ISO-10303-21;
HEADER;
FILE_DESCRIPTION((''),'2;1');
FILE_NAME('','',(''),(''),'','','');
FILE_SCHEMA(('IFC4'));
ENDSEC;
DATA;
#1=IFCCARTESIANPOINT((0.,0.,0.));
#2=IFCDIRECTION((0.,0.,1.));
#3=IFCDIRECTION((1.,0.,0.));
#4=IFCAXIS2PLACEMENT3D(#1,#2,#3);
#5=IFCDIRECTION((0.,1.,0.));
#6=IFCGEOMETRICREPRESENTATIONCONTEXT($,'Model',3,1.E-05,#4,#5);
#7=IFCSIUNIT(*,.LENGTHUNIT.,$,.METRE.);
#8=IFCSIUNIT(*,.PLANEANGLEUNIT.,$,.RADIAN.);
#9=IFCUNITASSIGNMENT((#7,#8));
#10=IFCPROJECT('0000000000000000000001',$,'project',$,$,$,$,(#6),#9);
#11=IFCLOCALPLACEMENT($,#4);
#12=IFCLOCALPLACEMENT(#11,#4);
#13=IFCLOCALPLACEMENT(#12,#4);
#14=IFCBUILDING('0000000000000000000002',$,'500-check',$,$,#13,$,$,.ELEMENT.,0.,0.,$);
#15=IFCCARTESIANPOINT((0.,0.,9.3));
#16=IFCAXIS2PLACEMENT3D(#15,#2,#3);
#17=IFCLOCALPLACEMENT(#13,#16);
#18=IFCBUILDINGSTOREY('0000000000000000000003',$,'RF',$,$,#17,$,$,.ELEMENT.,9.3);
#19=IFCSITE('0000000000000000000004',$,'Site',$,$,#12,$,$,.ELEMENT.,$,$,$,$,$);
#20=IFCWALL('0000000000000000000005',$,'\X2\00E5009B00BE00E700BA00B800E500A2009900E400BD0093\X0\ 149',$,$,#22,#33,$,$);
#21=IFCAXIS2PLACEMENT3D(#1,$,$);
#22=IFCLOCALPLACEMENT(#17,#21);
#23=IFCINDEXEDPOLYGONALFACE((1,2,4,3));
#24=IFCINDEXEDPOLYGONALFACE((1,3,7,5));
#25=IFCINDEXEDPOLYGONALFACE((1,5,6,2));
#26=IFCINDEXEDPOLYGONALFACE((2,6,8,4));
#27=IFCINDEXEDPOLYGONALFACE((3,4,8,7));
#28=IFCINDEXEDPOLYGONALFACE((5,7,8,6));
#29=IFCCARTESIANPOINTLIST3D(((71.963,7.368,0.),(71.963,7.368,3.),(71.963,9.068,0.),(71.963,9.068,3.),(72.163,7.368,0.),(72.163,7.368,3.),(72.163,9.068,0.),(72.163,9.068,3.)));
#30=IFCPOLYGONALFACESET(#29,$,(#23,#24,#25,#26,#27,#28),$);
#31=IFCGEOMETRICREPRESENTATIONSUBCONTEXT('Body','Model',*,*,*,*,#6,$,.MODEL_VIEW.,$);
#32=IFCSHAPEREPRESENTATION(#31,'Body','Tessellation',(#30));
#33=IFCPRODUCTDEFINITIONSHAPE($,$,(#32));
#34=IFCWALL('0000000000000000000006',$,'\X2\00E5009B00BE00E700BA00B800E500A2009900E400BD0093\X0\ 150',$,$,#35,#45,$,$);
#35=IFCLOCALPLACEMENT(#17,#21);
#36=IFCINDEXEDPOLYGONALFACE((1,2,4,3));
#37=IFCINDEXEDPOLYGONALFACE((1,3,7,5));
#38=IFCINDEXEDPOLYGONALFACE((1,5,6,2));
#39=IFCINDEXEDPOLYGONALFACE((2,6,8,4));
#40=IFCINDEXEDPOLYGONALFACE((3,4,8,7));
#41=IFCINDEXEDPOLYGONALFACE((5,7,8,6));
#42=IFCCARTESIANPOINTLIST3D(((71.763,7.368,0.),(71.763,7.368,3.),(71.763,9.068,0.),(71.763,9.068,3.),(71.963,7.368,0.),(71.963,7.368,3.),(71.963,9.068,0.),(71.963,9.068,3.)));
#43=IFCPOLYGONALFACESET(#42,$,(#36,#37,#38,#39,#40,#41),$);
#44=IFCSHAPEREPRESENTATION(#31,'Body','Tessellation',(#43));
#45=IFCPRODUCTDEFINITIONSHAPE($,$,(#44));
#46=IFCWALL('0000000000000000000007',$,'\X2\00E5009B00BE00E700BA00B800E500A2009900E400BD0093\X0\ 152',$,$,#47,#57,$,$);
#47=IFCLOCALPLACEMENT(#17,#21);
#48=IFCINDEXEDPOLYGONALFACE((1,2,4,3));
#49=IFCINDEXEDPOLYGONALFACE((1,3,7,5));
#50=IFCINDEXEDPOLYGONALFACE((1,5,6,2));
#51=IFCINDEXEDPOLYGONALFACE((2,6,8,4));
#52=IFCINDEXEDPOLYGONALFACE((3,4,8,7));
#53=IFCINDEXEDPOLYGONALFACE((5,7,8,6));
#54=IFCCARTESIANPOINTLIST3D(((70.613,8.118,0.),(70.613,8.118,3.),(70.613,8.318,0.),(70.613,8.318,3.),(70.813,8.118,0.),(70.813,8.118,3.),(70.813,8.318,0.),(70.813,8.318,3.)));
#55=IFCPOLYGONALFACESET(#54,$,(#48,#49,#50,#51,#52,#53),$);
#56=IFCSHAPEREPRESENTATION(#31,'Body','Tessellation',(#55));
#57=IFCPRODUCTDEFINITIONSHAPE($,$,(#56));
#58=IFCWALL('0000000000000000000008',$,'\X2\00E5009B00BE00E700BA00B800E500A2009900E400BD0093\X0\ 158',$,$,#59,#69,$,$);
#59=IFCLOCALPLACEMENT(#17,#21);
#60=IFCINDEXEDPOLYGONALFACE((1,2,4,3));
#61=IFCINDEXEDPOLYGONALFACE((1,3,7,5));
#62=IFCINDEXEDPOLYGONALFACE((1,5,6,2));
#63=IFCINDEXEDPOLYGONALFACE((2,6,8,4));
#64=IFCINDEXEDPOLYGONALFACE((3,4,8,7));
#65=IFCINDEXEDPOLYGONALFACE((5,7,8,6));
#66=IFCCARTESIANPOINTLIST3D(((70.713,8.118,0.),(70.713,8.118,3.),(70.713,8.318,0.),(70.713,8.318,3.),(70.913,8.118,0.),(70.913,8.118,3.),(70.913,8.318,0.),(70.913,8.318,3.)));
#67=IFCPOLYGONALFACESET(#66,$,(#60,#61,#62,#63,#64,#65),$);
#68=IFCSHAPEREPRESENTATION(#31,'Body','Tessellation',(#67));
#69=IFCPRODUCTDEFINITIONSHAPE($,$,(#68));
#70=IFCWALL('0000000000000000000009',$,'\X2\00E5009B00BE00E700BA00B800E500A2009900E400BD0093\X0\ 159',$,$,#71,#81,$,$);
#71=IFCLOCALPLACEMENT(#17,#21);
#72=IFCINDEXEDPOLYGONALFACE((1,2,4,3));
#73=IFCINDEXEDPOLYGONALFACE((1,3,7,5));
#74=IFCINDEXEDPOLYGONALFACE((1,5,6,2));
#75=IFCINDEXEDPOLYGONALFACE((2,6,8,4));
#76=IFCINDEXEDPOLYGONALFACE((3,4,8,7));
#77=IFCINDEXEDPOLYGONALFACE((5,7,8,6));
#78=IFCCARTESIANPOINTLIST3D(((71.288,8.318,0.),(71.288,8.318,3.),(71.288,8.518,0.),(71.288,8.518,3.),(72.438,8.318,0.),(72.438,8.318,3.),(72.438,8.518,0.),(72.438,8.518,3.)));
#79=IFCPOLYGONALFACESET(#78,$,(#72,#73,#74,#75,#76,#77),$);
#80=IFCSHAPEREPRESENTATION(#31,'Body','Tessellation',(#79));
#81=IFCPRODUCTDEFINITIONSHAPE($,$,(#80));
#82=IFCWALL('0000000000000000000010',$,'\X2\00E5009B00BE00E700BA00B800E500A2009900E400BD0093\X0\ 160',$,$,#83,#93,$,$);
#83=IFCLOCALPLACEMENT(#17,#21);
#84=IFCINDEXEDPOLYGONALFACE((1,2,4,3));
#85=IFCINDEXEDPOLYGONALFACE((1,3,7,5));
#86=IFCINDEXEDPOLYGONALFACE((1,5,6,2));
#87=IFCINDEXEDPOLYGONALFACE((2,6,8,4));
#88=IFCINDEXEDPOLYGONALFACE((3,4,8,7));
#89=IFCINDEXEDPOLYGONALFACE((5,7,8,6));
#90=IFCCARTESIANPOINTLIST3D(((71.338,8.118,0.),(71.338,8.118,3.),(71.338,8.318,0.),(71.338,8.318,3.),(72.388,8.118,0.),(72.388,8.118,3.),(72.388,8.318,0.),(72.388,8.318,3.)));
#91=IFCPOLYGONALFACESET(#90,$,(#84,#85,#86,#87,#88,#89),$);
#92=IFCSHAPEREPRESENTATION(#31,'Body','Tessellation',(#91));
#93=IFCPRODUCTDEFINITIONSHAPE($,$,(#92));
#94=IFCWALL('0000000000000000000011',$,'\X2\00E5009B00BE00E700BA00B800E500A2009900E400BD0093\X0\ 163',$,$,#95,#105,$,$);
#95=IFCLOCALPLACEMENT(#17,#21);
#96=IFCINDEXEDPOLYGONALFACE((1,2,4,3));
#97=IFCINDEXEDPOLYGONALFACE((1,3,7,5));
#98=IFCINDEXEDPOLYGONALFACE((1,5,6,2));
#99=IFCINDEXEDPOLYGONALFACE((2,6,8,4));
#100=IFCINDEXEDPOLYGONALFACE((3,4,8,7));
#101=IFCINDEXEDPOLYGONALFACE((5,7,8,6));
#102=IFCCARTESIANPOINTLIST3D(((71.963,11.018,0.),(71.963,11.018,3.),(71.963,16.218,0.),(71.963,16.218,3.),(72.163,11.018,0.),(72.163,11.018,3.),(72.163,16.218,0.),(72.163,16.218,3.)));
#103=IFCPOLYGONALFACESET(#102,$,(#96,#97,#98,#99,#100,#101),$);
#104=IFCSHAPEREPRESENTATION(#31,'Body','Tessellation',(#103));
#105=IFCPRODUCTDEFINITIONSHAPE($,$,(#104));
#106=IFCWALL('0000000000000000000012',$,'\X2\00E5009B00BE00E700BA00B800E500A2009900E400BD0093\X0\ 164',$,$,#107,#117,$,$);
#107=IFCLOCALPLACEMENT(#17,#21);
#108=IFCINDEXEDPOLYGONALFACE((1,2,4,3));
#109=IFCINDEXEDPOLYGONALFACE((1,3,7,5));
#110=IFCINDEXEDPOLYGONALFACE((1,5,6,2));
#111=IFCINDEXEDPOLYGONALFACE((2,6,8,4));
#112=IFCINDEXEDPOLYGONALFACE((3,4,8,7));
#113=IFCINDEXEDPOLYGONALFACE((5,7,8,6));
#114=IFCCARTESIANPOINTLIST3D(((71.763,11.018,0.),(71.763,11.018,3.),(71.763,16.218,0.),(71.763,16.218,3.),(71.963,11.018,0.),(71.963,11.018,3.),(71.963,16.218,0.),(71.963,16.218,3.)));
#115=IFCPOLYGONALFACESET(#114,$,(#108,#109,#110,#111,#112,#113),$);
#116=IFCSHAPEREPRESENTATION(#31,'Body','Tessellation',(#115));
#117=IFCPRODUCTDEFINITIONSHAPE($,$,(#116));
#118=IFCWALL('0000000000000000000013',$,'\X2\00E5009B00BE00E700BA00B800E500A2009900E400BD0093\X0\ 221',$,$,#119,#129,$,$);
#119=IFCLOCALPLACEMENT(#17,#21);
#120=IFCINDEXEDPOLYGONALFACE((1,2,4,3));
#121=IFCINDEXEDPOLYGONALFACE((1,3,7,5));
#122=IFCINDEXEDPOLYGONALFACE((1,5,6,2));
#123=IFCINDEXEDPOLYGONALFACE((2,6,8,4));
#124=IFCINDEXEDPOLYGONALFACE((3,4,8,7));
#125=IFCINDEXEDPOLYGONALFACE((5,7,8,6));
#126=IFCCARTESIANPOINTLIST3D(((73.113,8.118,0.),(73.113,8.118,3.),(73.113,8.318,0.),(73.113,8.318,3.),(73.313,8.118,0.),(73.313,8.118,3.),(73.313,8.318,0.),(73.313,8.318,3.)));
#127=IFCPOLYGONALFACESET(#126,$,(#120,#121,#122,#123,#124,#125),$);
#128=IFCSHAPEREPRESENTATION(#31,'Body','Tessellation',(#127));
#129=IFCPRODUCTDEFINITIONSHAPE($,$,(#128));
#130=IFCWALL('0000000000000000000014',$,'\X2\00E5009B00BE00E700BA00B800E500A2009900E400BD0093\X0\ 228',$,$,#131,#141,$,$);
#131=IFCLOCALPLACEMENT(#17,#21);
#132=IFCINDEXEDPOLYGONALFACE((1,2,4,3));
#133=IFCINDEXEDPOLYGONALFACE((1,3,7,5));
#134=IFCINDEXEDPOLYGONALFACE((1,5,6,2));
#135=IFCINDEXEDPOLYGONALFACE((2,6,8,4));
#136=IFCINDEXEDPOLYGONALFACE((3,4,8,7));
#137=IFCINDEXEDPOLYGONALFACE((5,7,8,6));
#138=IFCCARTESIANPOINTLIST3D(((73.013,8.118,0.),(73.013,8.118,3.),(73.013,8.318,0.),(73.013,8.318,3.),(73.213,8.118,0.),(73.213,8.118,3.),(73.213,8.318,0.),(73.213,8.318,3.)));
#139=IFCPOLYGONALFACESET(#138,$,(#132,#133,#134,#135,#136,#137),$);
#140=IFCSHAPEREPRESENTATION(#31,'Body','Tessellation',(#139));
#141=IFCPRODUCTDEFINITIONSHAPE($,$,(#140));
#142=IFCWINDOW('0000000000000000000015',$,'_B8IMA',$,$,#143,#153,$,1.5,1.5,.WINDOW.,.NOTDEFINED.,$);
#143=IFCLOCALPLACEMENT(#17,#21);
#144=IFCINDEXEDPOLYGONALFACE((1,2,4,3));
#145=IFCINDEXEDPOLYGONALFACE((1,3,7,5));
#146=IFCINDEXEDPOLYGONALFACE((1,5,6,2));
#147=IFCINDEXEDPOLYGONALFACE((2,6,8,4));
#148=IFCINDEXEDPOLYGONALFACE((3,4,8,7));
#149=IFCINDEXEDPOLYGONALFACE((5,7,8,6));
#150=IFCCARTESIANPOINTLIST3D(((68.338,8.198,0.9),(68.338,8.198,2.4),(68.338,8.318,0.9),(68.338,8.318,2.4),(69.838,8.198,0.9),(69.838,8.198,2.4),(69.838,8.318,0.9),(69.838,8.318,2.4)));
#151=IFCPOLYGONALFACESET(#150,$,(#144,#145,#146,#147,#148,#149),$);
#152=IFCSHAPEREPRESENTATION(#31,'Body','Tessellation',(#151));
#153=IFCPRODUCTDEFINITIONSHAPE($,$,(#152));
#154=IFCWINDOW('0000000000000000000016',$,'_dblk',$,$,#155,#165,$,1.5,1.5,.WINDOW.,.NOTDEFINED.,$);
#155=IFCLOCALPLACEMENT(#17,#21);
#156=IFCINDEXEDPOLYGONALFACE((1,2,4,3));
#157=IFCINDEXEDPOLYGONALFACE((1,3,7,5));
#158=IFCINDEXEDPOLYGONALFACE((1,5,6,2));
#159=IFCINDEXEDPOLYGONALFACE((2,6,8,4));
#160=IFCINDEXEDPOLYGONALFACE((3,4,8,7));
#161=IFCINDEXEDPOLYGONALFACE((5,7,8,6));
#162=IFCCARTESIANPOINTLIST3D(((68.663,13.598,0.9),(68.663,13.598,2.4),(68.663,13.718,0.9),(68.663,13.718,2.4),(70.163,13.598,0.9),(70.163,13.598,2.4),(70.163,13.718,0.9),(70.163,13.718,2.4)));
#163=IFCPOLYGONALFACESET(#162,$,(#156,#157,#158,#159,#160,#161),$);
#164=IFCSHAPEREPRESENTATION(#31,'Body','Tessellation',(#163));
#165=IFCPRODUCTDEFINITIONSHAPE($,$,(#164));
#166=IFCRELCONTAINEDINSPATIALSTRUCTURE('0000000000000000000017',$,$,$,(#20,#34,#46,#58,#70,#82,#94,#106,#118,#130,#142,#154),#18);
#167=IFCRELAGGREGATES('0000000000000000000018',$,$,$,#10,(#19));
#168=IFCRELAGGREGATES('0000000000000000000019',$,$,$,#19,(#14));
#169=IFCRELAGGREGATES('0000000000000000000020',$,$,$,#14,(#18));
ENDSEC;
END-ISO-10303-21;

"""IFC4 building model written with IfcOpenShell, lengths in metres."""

from ifc_helpers import new_model, si_unit, direction, frame, frame_2d, origin_with_axes, place, context, subcontext, project, spatial, rectangle, extrude, element, save


model = new_model("IFC4")

# Units and contexts
model_context = context("Model", 3, precision=1e-05, world=origin_with_axes(), true_north=direction((0.0, 1.0, 0.0)))
body_context = subcontext(model_context, "Body", "Model", "MODEL_VIEW")
ifc_project = project(units=[si_unit("LENGTHUNIT", "METRE"), si_unit("PLANEANGLEUNIT", "RADIAN")], contexts=[model_context])

# Site, building, storey
placement = place(None, origin_with_axes())
site_placement = place(placement, origin_with_axes())
site = spatial("IfcSite", under=ifc_project, at=site_placement, Name="Site", CompositionType="ELEMENT")
building_placement = place(site_placement, origin_with_axes())
building = spatial("IfcBuilding", under=site, at=building_placement, Name="500-check", CompositionType="ELEMENT", ElevationOfRefHeight=0.0, ElevationOfTerrain=0.0)
storey_placement = place(building_placement, frame((0.0, 0.0, 9.3), z_axis=(0.0, 0.0, 1.0), x_axis=(1.0, 0.0, 0.0)))
storey = spatial("IfcBuildingStorey", under=building, at=storey_placement, Name="RF", CompositionType="ELEMENT", Elevation=9.3)

# Walls
for number, where, z_axis, x_axis, name in (
    (1, (72.063, 8.218, 0.0), (0.0, 0.0, 1.0), (0.0, -1.0, 0.0), "å\u009b¾çº¸å¢\u0099ä½\u0093 149"),
    (2, (71.863, 8.218, 0.0), (0.0, 0.0, 1.0), (0.0, -1.0, 0.0), "å\u009b¾çº¸å¢\u0099ä½\u0093 150"),
):
    element("IfcWall", number, at=place(storey_placement, frame(where, z_axis=z_axis, x_axis=x_axis)), inside=storey, Name=name, context=body_context, shape_type="SweptSolid", body=[
        extrude(rectangle(XDim=1.7, YDim=0.2, at=frame_2d((0.0, 0.0), x_axis=(1.0, 0.0, 0.0))), frame((0.0, 0.0, 0.0), z_axis=(0.0, 0.0, 1.0)), (0.0, 0.0, 1.0), 3.0),
    ])
for number, where, z_axis, x_axis, name in (
    (3, (70.713, 8.218, 0.0), (0.0, 0.0, 1.0), (0.0, 1.0, 0.0), "å\u009b¾çº¸å¢\u0099ä½\u0093 152"),
    (4, (70.813, 8.218, 0.0), (0.0, 0.0, 1.0), (0.0, -1.0, 0.0), "å\u009b¾çº¸å¢\u0099ä½\u0093 158"),
):
    element("IfcWall", number, at=place(storey_placement, frame(where, z_axis=z_axis, x_axis=x_axis)), inside=storey, Name=name, context=body_context, shape_type="SweptSolid", body=[
        extrude(rectangle(XDim=0.2, YDim=0.2, at=frame_2d((0.0, 0.0), x_axis=(1.0, 0.0, 0.0))), frame((0.0, 0.0, 0.0), z_axis=(0.0, 0.0, 1.0)), (0.0, 0.0, 1.0), 3.0),
    ])
wall_1_placement = place(storey_placement, frame((71.863, 8.418, 0.0), z_axis=(0.0, 0.0, 1.0), x_axis=(-1.0, 0.0, 0.0)))
element("IfcWall", 5, at=wall_1_placement, inside=storey, Name="å\u009b¾çº¸å¢\u0099ä½\u0093 159", context=body_context, shape_type="SweptSolid", body=[
    extrude(rectangle(XDim=1.15, YDim=0.2, at=frame_2d((0.0, 0.0), x_axis=(1.0, 0.0, 0.0))), frame((0.0, 0.0, 0.0), z_axis=(0.0, 0.0, 1.0)), (0.0, 0.0, 1.0), 3.0),
])
wall_2_placement = place(storey_placement, frame((71.863, 8.218, 0.0), z_axis=(0.0, 0.0, 1.0), x_axis=(-1.0, 0.0, 0.0)))
element("IfcWall", 6, at=wall_2_placement, inside=storey, Name="å\u009b¾çº¸å¢\u0099ä½\u0093 160", context=body_context, shape_type="SweptSolid", body=[
    extrude(rectangle(XDim=1.05, YDim=0.2, at=frame_2d((0.0, 0.0), x_axis=(1.0, 0.0, 0.0))), frame((0.0, 0.0, 0.0), z_axis=(0.0, 0.0, 1.0)), (0.0, 0.0, 1.0), 3.0),
])
for number, where, z_axis, x_axis, name in (
    (7, (72.063, 13.618, 0.0), (0.0, 0.0, 1.0), (0.0, -1.0, 0.0), "å\u009b¾çº¸å¢\u0099ä½\u0093 163"),
    (8, (71.863, 13.618, 0.0), (0.0, 0.0, 1.0), (0.0, -1.0, 0.0), "å\u009b¾çº¸å¢\u0099ä½\u0093 164"),
):
    element("IfcWall", number, at=place(storey_placement, frame(where, z_axis=z_axis, x_axis=x_axis)), inside=storey, Name=name, context=body_context, shape_type="SweptSolid", body=[
        extrude(rectangle(XDim=5.2, YDim=0.2, at=frame_2d((0.0, 0.0), x_axis=(1.0, 0.0, 0.0))), frame((0.0, 0.0, 0.0), z_axis=(0.0, 0.0, 1.0)), (0.0, 0.0, 1.0), 3.0),
    ])
for number, where, z_axis, x_axis, name in (
    (9, (73.213, 8.218, 0.0), (0.0, 0.0, 1.0), (0.0, 1.0, 0.0), "å\u009b¾çº¸å¢\u0099ä½\u0093 221"),
    (10, (73.113, 8.218, 0.0), (0.0, 0.0, 1.0), (0.0, -1.0, 0.0), "å\u009b¾çº¸å¢\u0099ä½\u0093 228"),
):
    element("IfcWall", number, at=place(storey_placement, frame(where, z_axis=z_axis, x_axis=x_axis)), inside=storey, Name=name, context=body_context, shape_type="SweptSolid", body=[
        extrude(rectangle(XDim=0.2, YDim=0.2, at=frame_2d((0.0, 0.0), x_axis=(1.0, 0.0, 0.0))), frame((0.0, 0.0, 0.0), z_axis=(0.0, 0.0, 1.0)), (0.0, 0.0, 1.0), 3.0),
    ])

# Windows
for number, where, z_axis, x_axis, name in (
    (11, (69.088, 8.258, 0.9), (0.0, 0.0, 1.0), (1.0, 0.0, 0.0), "_B8IMA"),
    (12, (69.413, 13.658, 0.9), (0.0, 0.0, 1.0), (1.0, 0.0, 0.0), "_dblk"),
):
    element("IfcWindow", number, at=place(storey_placement, frame(where, z_axis=z_axis, x_axis=x_axis)), inside=storey, Name=name, OverallHeight=1.5, OverallWidth=1.5, PartitioningType="NOTDEFINED", PredefinedType="WINDOW", context=body_context, shape_type="SweptSolid", body=[
        extrude(rectangle(XDim=1.5, YDim=0.12, at=frame_2d((0.0, 0.0), x_axis=(1.0, 0.0, 0.0))), frame((0.0, 0.0, 0.0), z_axis=(0.0, 0.0, 1.0)), (0.0, 0.0, 1.0), 1.5),
    ])

save(model, "model.ifc")
